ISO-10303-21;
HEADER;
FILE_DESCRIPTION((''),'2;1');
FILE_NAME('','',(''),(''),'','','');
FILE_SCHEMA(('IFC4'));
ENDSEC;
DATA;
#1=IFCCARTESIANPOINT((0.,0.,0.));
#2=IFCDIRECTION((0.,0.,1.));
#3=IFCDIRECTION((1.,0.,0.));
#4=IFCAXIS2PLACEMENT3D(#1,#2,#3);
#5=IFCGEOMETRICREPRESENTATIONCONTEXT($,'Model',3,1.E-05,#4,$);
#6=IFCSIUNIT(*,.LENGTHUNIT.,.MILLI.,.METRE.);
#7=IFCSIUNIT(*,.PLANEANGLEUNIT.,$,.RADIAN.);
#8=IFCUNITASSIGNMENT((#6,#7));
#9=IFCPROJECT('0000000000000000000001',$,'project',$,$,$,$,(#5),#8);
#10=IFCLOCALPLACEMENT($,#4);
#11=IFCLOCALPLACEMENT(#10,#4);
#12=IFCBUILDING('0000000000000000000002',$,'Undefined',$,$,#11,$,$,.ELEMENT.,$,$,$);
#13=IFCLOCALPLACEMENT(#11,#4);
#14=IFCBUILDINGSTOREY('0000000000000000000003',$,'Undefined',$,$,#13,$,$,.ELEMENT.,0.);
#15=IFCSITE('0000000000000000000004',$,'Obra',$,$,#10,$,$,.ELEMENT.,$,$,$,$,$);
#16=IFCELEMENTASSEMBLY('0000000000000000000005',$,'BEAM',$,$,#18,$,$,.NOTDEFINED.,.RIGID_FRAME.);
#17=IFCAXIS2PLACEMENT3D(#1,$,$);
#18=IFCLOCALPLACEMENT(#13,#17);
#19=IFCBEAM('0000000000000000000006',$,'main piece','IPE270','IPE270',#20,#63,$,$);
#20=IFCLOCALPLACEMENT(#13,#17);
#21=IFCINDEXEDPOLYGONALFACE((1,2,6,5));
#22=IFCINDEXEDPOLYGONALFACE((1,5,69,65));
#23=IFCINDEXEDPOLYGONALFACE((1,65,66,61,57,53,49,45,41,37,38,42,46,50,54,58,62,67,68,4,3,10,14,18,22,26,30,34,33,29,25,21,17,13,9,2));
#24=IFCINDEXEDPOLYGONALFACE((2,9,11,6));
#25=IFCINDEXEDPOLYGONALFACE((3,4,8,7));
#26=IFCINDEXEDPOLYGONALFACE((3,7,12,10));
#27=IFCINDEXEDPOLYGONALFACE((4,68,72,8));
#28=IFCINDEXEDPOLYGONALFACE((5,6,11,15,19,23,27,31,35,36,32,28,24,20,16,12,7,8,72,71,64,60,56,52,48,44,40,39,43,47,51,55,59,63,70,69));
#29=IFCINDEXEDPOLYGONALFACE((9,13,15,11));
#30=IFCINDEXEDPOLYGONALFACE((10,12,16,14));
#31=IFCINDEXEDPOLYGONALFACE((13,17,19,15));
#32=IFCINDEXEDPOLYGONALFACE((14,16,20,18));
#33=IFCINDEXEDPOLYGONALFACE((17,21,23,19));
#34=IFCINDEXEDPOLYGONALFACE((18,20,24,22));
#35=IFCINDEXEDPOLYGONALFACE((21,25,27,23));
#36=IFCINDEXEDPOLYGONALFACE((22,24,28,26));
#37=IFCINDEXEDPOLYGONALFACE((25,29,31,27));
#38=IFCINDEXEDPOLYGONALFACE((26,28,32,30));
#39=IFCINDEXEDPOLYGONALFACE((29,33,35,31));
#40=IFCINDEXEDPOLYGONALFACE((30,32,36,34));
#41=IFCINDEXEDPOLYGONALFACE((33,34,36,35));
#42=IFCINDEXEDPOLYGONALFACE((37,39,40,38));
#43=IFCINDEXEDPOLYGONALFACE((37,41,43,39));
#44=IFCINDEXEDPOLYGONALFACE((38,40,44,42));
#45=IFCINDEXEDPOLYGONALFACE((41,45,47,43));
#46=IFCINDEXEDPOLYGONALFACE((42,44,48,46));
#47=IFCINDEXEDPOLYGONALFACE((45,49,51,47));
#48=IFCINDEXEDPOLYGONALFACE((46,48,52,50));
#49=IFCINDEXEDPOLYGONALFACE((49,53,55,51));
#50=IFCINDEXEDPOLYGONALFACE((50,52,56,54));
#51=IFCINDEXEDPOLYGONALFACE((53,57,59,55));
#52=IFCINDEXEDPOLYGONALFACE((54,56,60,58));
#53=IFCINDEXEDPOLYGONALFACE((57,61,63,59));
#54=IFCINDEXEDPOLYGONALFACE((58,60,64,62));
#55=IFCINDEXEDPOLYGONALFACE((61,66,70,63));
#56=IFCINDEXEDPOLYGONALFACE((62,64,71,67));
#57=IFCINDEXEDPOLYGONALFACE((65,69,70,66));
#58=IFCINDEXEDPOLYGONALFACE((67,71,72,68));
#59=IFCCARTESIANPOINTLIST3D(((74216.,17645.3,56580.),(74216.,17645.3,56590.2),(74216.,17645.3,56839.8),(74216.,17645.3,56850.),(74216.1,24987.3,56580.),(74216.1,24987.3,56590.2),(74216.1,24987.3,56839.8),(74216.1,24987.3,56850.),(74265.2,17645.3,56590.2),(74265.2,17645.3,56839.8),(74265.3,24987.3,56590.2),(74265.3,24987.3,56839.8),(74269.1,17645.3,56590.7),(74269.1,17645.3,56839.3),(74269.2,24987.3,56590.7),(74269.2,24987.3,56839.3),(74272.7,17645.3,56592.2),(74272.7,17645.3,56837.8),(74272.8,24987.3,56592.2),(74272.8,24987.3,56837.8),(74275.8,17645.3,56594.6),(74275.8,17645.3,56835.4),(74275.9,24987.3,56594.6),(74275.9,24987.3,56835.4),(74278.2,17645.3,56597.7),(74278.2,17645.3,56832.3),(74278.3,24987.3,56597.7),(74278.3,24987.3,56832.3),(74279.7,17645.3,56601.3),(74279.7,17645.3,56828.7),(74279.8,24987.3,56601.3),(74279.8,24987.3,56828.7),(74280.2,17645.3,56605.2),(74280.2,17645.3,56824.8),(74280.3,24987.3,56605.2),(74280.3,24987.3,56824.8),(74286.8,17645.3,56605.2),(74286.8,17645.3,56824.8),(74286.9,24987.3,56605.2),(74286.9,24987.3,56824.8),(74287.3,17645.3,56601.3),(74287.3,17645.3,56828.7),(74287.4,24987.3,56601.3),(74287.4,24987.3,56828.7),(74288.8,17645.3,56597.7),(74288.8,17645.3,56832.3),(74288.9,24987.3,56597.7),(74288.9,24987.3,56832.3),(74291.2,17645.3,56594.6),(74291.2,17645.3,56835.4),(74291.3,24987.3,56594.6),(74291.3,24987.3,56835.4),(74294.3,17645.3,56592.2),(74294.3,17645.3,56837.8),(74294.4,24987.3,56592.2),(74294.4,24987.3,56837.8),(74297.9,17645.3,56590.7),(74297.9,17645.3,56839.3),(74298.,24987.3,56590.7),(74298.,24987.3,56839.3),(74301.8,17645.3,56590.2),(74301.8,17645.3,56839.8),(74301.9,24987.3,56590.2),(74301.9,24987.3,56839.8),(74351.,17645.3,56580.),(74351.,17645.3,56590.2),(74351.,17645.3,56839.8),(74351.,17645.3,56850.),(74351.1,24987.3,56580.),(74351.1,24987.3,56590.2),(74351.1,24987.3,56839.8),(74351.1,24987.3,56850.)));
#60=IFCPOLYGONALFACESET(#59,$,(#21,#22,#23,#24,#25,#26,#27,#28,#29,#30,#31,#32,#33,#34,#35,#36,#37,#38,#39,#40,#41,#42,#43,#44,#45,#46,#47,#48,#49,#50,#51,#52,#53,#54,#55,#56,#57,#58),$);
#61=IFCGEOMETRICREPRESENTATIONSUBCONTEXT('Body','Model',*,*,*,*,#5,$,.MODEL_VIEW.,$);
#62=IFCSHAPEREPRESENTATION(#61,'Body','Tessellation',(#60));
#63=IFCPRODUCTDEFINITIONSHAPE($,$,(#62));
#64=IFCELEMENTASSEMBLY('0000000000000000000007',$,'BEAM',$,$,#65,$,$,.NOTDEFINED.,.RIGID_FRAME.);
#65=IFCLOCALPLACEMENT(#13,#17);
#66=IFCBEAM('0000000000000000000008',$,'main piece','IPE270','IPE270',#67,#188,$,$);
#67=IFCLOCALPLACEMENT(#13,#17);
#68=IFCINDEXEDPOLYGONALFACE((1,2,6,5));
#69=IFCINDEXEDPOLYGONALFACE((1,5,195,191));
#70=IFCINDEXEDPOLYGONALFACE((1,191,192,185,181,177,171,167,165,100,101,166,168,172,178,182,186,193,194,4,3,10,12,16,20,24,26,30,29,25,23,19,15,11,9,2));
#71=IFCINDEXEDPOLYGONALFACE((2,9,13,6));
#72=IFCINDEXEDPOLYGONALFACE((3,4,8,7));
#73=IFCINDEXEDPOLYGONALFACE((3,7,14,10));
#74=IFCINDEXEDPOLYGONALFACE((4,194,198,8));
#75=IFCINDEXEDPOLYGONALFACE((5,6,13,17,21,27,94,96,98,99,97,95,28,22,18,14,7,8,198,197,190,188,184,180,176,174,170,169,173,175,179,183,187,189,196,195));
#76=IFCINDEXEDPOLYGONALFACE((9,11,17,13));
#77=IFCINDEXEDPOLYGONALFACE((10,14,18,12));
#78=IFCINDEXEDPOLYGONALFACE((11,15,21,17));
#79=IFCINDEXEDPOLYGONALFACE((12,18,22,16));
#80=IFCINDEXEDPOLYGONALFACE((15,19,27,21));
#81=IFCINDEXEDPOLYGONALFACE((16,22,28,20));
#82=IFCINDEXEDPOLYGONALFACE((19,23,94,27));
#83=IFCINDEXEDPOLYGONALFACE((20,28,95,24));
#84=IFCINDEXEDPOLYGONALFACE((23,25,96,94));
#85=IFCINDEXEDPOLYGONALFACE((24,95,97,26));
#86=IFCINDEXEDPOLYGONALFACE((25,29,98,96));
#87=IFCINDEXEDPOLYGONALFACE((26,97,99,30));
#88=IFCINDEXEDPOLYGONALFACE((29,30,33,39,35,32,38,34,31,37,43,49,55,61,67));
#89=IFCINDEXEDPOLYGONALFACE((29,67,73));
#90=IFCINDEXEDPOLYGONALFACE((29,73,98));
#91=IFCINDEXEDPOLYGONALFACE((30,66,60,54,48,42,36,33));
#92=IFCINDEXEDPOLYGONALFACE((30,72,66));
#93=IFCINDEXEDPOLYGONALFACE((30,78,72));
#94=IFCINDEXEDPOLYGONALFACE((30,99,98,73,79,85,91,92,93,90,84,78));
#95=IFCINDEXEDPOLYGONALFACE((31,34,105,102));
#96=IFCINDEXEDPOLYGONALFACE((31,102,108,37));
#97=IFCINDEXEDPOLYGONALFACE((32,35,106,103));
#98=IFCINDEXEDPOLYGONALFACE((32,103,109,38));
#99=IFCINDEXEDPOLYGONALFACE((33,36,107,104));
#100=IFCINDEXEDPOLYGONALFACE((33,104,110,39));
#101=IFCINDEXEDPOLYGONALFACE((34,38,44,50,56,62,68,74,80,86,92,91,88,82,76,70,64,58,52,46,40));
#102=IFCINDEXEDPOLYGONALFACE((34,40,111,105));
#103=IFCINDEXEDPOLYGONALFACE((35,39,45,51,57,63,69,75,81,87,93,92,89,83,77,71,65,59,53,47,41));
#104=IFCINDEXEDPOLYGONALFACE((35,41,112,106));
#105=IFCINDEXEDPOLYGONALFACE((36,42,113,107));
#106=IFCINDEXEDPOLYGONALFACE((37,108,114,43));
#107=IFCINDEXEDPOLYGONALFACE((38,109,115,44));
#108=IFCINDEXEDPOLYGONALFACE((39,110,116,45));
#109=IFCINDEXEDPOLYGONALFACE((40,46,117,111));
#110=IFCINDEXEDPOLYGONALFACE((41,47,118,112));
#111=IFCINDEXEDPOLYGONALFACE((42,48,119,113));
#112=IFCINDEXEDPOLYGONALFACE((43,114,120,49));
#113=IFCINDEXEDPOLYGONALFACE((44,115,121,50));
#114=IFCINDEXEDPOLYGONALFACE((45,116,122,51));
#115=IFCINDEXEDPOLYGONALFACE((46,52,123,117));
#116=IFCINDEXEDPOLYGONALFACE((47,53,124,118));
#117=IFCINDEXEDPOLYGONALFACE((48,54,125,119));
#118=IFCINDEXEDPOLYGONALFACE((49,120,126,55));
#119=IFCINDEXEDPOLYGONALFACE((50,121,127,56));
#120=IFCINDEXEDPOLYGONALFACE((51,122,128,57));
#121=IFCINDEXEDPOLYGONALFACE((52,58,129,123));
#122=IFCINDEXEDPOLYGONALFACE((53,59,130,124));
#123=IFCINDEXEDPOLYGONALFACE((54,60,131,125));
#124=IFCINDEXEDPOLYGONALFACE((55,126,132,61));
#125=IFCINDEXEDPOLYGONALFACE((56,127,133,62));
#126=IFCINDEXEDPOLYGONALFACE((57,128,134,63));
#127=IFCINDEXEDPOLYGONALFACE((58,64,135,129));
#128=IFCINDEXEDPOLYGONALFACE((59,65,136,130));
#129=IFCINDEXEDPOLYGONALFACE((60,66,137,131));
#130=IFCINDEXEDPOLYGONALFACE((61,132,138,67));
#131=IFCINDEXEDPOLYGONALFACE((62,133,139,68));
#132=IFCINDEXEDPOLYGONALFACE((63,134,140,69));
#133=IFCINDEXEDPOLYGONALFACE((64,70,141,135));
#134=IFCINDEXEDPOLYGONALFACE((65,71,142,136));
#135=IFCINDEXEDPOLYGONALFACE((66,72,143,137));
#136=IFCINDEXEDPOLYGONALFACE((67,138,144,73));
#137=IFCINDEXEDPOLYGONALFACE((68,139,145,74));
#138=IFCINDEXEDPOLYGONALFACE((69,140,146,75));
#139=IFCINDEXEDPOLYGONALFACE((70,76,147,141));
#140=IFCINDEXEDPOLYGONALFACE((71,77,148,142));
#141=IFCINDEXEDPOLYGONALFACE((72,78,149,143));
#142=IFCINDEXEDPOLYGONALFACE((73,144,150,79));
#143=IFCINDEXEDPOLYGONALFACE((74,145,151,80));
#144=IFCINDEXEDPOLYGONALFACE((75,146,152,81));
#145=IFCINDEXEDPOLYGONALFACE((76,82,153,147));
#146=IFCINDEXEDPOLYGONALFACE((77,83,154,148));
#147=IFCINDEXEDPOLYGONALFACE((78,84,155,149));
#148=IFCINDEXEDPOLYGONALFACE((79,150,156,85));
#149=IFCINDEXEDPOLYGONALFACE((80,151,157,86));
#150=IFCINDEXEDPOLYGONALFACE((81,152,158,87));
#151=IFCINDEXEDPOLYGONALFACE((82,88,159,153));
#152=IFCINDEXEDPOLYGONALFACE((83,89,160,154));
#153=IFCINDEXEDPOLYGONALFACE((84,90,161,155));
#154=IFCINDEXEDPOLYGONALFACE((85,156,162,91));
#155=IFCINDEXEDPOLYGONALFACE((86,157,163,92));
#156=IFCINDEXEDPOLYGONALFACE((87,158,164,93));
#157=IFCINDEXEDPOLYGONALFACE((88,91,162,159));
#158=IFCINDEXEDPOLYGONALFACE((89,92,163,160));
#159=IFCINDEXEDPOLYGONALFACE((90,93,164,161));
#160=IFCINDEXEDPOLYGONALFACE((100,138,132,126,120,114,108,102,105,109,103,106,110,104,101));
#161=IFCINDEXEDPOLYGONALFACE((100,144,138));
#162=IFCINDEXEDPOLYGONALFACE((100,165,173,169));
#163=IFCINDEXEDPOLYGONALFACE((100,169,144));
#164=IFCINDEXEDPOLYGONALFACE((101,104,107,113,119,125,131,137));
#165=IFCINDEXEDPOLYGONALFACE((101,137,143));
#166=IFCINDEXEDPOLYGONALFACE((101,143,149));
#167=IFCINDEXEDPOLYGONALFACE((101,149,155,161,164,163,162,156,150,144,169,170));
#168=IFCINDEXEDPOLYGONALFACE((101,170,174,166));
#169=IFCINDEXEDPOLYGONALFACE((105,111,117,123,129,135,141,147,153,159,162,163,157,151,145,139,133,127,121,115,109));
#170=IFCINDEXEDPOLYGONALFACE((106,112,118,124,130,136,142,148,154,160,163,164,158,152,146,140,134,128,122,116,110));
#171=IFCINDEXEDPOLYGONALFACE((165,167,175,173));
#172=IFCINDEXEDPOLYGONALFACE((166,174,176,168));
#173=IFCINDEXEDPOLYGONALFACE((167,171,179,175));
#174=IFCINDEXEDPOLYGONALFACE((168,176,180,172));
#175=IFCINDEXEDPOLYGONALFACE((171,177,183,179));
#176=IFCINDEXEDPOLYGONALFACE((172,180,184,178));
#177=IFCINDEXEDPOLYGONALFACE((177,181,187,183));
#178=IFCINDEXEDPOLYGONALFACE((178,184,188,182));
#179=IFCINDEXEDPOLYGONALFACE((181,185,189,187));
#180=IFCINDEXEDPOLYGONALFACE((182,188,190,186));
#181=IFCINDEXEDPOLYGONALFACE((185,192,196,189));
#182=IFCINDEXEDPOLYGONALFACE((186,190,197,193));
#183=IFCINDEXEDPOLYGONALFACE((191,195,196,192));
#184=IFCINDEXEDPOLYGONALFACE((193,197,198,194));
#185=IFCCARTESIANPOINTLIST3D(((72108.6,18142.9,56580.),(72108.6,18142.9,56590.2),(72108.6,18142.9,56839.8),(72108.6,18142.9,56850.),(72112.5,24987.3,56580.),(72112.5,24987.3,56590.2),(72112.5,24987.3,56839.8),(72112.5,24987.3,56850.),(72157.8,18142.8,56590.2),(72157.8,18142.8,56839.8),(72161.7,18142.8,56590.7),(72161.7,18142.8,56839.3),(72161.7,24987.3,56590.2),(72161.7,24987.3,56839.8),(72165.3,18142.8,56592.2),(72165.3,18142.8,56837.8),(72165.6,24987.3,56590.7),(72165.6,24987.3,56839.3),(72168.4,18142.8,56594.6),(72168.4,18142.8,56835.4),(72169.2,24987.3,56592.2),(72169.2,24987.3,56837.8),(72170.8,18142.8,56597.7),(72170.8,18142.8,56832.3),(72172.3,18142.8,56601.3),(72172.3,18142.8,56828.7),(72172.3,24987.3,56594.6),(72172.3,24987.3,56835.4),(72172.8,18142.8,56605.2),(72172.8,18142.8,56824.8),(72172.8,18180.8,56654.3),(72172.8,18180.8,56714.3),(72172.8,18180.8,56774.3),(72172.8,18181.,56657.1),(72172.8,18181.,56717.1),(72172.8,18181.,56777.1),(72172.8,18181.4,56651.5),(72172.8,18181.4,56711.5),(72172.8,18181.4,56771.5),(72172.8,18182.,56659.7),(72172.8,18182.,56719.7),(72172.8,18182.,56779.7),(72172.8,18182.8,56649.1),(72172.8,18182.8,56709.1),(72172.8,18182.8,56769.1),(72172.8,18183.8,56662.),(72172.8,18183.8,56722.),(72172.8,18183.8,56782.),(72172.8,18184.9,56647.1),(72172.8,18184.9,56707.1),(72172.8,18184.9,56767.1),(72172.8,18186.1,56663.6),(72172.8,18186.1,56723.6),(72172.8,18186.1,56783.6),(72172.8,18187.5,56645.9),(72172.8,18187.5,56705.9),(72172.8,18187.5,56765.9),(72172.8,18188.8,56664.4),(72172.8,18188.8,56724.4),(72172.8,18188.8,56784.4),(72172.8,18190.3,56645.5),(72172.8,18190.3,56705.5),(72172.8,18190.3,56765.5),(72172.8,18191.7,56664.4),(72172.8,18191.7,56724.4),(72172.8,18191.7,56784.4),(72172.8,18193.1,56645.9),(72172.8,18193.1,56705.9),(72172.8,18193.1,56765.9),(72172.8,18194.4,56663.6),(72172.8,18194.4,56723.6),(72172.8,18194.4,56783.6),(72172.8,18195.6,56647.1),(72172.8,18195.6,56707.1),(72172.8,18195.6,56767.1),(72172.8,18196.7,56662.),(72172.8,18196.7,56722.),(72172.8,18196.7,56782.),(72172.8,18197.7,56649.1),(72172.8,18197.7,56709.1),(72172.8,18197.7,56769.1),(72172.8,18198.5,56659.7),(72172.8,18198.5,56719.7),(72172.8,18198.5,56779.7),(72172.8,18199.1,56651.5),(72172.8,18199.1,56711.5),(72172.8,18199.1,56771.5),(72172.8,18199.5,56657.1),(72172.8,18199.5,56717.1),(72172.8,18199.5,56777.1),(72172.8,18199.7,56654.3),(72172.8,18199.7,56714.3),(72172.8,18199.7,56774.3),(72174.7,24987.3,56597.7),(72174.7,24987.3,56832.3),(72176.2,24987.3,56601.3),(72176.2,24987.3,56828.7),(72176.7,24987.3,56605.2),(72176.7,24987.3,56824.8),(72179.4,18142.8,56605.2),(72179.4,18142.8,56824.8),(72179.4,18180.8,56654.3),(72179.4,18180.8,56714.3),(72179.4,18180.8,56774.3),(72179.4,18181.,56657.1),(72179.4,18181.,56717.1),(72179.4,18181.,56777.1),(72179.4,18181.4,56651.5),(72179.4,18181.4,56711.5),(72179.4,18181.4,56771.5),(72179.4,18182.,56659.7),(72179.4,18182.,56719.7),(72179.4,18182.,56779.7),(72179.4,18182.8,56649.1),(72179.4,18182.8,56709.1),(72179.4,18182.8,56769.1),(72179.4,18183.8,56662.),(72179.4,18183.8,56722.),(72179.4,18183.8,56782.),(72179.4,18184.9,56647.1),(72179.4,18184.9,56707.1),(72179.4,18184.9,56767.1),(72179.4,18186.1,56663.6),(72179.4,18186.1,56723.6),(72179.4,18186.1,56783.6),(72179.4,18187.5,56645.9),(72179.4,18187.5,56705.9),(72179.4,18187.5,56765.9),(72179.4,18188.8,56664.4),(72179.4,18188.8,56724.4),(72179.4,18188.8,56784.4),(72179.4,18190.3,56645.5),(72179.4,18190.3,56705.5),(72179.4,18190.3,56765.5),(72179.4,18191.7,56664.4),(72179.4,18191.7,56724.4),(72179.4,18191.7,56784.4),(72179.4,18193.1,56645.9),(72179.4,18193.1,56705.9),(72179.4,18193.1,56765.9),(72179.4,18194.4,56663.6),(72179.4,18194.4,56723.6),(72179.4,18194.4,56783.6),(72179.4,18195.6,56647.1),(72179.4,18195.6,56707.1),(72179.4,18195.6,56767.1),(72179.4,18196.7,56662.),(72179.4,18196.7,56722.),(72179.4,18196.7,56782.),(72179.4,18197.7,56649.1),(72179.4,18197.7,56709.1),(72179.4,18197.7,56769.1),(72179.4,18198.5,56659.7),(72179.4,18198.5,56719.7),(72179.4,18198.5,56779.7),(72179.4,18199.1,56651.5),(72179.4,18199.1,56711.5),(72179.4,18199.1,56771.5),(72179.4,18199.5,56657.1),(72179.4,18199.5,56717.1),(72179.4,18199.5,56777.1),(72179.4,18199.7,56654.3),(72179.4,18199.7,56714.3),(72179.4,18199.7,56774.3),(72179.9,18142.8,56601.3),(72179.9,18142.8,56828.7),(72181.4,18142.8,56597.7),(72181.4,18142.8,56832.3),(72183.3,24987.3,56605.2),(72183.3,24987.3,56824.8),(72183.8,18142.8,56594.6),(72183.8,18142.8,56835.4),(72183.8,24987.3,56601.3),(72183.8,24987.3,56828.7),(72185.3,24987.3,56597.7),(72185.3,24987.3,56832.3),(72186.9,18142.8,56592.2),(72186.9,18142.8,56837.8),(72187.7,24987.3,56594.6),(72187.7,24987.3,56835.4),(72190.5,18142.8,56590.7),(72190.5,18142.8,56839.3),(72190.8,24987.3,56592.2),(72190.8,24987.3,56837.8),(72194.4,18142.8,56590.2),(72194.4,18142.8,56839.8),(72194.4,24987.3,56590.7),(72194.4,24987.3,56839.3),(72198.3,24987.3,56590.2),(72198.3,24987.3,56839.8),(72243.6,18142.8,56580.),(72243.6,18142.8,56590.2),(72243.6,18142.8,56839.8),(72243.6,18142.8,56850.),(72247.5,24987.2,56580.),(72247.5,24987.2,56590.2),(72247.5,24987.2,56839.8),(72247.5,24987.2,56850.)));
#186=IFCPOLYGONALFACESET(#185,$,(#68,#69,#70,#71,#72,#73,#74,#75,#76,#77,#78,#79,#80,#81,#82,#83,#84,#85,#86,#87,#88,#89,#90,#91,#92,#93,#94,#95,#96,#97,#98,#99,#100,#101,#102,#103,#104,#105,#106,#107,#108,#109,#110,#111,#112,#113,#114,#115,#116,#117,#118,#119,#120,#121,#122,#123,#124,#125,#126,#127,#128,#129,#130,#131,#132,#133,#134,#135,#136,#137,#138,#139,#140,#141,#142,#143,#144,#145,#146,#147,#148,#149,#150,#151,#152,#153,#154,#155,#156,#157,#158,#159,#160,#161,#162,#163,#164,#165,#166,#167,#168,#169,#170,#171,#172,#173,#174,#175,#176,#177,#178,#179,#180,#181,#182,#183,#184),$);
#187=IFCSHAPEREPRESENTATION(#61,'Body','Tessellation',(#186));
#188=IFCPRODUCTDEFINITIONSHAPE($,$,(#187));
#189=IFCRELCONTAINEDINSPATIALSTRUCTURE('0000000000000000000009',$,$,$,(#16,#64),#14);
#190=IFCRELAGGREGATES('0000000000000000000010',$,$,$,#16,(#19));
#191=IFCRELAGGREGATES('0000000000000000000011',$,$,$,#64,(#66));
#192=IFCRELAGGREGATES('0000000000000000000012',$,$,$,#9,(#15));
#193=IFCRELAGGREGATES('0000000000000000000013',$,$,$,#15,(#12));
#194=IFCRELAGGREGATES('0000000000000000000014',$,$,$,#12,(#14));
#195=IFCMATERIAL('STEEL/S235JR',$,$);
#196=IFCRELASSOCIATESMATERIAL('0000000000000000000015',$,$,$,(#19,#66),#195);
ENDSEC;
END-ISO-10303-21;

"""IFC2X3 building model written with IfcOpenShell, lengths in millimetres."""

from ifc_helpers import new_model, si_unit, frame, origin_with_axes, origin_2d_with_axis, place, context, subcontext, project, spatial, circle, i_section, extrude, clip, halfspace, source, transform, mapped, material, element, aggregate, save


model = new_model("IFC2X3")

# Units and contexts
model_context = context("Model", 3, precision=1e-05, world=origin_with_axes())
body_context = subcontext(model_context, "Body", "Model", "MODEL_VIEW")
ifc_project = project(units=[si_unit("LENGTHUNIT", "METRE", prefix="MILLI"), si_unit("PLANEANGLEUNIT", "RADIAN")], contexts=[model_context])

# Site, building, storey
site_placement = place(None, origin_with_axes())
site = spatial("IfcSite", under=ifc_project, at=site_placement, Name="Obra", CompositionType="ELEMENT")
building_placement = place(site_placement, origin_with_axes())
building = spatial("IfcBuilding", under=site, at=building_placement, Name="Undefined", CompositionType="ELEMENT")
storey_placement = place(building_placement, origin_with_axes())
storey = spatial("IfcBuildingStorey", under=building, at=storey_placement, Name="Undefined", CompositionType="ELEMENT", Elevation=0.0)

# Shared definitions
ifc_material = material(Name="STEEL/S235JR")

# Element assembly, beam
assembly_1_placement = place(storey_placement, origin_with_axes())
assembly_1 = element("IfcElementAssembly", 1, at=assembly_1_placement, inside=storey, Name="BEAM", AssemblyPlace="NOTDEFINED", PredefinedType="RIGID_FRAME")
beam_1_placement = place(assembly_1_placement, frame((74283.5, 17645.3, 56715.0), z_axis=(0.0, 0.0, 1.0), x_axis=(0.000013, 1.0, 0.0)))
beam_1 = element("IfcBeam", 2, at=beam_1_placement, material=ifc_material, Name="main piece", Description="IPE270", ObjectType="IPE270", context=body_context, shape_type="SweptSolid", body=[
    extrude(i_section(OverallWidth=135.0, OverallDepth=270.0, WebThickness=6.6, FlangeThickness=10.2, FilletRadius=15.0, at=origin_2d_with_axis()), frame((7342.1, 0.0, 0.0), z_axis=(-1.0, 0.0, 0.0), x_axis=(0.0, -1.0, 0.0)), (0.0, 0.0, 1.0), 7342.1),
])
aggregate(assembly_1, [beam_1])

# Element assembly, beam, opening
assembly_2_placement = place(storey_placement, origin_with_axes())
assembly_2 = element("IfcElementAssembly", 3, at=assembly_2_placement, inside=storey, Name="BEAM", AssemblyPlace="NOTDEFINED", PredefinedType="RIGID_FRAME")
beam_2_placement = place(assembly_2_placement, frame((72180.0, 24987.3, 56715.0), z_axis=(0.0, 0.0, 1.0), x_axis=(-0.000568, -1.0, 0.0)))
beam_2 = element("IfcBeam", 4, at=beam_2_placement, material=ifc_material, Name="main piece", Description="IPE270", ObjectType="IPE270", context=body_context, shape_type="Clipping", body=[
    clip(extrude(i_section(OverallWidth=135.0, OverallDepth=270.0, WebThickness=6.6, FlangeThickness=10.2, FilletRadius=15.0, at=origin_2d_with_axis()), frame((6844.4, 0.0, 0.0), z_axis=(-1.0, 0.0, 0.0), x_axis=(0.0, -1.0, 0.0)), (0.0, 0.0, 1.0), 6844.4), halfspace(frame((6846.6, -60.3, -120.0), z_axis=(1.0, 0.000586, 0.0), x_axis=(0.0, 0.0, 1.0)), False)),
])
shared_shape_1 = source(origin_with_axes(), body_context, "Body", "SweptSolid", [
    extrude(circle(Radius=9.5, at=origin_2d_with_axis()), frame((0.0, -3.7, 0.0), z_axis=(0.0, 1.0, 0.0), x_axis=(1.0, 0.0, 0.0)), (0.0, 0.0, 1.0), 6.8),
])
opening_1_placement = place(assembly_2_placement, frame((72175.8, 18140.3, 56835.0), z_axis=(0.0, 1.0, 0.0), x_axis=(0.0, 0.0, -1.0)))
element("IfcOpeningElement", 5, at=opening_1_placement, cuts=beam_2, ObjectType="Opening", context=body_context, shape_type="MappedRepresentation", body=[
    mapped(shared_shape_1, transform((60.0, 0.0, 50.0))),
    mapped(shared_shape_1, transform((120.0, 0.0, 50.0))),
    mapped(shared_shape_1, transform((180.0, 0.0, 50.0))),
])
aggregate(assembly_2, [beam_2])

save(model, "model.ifc")
